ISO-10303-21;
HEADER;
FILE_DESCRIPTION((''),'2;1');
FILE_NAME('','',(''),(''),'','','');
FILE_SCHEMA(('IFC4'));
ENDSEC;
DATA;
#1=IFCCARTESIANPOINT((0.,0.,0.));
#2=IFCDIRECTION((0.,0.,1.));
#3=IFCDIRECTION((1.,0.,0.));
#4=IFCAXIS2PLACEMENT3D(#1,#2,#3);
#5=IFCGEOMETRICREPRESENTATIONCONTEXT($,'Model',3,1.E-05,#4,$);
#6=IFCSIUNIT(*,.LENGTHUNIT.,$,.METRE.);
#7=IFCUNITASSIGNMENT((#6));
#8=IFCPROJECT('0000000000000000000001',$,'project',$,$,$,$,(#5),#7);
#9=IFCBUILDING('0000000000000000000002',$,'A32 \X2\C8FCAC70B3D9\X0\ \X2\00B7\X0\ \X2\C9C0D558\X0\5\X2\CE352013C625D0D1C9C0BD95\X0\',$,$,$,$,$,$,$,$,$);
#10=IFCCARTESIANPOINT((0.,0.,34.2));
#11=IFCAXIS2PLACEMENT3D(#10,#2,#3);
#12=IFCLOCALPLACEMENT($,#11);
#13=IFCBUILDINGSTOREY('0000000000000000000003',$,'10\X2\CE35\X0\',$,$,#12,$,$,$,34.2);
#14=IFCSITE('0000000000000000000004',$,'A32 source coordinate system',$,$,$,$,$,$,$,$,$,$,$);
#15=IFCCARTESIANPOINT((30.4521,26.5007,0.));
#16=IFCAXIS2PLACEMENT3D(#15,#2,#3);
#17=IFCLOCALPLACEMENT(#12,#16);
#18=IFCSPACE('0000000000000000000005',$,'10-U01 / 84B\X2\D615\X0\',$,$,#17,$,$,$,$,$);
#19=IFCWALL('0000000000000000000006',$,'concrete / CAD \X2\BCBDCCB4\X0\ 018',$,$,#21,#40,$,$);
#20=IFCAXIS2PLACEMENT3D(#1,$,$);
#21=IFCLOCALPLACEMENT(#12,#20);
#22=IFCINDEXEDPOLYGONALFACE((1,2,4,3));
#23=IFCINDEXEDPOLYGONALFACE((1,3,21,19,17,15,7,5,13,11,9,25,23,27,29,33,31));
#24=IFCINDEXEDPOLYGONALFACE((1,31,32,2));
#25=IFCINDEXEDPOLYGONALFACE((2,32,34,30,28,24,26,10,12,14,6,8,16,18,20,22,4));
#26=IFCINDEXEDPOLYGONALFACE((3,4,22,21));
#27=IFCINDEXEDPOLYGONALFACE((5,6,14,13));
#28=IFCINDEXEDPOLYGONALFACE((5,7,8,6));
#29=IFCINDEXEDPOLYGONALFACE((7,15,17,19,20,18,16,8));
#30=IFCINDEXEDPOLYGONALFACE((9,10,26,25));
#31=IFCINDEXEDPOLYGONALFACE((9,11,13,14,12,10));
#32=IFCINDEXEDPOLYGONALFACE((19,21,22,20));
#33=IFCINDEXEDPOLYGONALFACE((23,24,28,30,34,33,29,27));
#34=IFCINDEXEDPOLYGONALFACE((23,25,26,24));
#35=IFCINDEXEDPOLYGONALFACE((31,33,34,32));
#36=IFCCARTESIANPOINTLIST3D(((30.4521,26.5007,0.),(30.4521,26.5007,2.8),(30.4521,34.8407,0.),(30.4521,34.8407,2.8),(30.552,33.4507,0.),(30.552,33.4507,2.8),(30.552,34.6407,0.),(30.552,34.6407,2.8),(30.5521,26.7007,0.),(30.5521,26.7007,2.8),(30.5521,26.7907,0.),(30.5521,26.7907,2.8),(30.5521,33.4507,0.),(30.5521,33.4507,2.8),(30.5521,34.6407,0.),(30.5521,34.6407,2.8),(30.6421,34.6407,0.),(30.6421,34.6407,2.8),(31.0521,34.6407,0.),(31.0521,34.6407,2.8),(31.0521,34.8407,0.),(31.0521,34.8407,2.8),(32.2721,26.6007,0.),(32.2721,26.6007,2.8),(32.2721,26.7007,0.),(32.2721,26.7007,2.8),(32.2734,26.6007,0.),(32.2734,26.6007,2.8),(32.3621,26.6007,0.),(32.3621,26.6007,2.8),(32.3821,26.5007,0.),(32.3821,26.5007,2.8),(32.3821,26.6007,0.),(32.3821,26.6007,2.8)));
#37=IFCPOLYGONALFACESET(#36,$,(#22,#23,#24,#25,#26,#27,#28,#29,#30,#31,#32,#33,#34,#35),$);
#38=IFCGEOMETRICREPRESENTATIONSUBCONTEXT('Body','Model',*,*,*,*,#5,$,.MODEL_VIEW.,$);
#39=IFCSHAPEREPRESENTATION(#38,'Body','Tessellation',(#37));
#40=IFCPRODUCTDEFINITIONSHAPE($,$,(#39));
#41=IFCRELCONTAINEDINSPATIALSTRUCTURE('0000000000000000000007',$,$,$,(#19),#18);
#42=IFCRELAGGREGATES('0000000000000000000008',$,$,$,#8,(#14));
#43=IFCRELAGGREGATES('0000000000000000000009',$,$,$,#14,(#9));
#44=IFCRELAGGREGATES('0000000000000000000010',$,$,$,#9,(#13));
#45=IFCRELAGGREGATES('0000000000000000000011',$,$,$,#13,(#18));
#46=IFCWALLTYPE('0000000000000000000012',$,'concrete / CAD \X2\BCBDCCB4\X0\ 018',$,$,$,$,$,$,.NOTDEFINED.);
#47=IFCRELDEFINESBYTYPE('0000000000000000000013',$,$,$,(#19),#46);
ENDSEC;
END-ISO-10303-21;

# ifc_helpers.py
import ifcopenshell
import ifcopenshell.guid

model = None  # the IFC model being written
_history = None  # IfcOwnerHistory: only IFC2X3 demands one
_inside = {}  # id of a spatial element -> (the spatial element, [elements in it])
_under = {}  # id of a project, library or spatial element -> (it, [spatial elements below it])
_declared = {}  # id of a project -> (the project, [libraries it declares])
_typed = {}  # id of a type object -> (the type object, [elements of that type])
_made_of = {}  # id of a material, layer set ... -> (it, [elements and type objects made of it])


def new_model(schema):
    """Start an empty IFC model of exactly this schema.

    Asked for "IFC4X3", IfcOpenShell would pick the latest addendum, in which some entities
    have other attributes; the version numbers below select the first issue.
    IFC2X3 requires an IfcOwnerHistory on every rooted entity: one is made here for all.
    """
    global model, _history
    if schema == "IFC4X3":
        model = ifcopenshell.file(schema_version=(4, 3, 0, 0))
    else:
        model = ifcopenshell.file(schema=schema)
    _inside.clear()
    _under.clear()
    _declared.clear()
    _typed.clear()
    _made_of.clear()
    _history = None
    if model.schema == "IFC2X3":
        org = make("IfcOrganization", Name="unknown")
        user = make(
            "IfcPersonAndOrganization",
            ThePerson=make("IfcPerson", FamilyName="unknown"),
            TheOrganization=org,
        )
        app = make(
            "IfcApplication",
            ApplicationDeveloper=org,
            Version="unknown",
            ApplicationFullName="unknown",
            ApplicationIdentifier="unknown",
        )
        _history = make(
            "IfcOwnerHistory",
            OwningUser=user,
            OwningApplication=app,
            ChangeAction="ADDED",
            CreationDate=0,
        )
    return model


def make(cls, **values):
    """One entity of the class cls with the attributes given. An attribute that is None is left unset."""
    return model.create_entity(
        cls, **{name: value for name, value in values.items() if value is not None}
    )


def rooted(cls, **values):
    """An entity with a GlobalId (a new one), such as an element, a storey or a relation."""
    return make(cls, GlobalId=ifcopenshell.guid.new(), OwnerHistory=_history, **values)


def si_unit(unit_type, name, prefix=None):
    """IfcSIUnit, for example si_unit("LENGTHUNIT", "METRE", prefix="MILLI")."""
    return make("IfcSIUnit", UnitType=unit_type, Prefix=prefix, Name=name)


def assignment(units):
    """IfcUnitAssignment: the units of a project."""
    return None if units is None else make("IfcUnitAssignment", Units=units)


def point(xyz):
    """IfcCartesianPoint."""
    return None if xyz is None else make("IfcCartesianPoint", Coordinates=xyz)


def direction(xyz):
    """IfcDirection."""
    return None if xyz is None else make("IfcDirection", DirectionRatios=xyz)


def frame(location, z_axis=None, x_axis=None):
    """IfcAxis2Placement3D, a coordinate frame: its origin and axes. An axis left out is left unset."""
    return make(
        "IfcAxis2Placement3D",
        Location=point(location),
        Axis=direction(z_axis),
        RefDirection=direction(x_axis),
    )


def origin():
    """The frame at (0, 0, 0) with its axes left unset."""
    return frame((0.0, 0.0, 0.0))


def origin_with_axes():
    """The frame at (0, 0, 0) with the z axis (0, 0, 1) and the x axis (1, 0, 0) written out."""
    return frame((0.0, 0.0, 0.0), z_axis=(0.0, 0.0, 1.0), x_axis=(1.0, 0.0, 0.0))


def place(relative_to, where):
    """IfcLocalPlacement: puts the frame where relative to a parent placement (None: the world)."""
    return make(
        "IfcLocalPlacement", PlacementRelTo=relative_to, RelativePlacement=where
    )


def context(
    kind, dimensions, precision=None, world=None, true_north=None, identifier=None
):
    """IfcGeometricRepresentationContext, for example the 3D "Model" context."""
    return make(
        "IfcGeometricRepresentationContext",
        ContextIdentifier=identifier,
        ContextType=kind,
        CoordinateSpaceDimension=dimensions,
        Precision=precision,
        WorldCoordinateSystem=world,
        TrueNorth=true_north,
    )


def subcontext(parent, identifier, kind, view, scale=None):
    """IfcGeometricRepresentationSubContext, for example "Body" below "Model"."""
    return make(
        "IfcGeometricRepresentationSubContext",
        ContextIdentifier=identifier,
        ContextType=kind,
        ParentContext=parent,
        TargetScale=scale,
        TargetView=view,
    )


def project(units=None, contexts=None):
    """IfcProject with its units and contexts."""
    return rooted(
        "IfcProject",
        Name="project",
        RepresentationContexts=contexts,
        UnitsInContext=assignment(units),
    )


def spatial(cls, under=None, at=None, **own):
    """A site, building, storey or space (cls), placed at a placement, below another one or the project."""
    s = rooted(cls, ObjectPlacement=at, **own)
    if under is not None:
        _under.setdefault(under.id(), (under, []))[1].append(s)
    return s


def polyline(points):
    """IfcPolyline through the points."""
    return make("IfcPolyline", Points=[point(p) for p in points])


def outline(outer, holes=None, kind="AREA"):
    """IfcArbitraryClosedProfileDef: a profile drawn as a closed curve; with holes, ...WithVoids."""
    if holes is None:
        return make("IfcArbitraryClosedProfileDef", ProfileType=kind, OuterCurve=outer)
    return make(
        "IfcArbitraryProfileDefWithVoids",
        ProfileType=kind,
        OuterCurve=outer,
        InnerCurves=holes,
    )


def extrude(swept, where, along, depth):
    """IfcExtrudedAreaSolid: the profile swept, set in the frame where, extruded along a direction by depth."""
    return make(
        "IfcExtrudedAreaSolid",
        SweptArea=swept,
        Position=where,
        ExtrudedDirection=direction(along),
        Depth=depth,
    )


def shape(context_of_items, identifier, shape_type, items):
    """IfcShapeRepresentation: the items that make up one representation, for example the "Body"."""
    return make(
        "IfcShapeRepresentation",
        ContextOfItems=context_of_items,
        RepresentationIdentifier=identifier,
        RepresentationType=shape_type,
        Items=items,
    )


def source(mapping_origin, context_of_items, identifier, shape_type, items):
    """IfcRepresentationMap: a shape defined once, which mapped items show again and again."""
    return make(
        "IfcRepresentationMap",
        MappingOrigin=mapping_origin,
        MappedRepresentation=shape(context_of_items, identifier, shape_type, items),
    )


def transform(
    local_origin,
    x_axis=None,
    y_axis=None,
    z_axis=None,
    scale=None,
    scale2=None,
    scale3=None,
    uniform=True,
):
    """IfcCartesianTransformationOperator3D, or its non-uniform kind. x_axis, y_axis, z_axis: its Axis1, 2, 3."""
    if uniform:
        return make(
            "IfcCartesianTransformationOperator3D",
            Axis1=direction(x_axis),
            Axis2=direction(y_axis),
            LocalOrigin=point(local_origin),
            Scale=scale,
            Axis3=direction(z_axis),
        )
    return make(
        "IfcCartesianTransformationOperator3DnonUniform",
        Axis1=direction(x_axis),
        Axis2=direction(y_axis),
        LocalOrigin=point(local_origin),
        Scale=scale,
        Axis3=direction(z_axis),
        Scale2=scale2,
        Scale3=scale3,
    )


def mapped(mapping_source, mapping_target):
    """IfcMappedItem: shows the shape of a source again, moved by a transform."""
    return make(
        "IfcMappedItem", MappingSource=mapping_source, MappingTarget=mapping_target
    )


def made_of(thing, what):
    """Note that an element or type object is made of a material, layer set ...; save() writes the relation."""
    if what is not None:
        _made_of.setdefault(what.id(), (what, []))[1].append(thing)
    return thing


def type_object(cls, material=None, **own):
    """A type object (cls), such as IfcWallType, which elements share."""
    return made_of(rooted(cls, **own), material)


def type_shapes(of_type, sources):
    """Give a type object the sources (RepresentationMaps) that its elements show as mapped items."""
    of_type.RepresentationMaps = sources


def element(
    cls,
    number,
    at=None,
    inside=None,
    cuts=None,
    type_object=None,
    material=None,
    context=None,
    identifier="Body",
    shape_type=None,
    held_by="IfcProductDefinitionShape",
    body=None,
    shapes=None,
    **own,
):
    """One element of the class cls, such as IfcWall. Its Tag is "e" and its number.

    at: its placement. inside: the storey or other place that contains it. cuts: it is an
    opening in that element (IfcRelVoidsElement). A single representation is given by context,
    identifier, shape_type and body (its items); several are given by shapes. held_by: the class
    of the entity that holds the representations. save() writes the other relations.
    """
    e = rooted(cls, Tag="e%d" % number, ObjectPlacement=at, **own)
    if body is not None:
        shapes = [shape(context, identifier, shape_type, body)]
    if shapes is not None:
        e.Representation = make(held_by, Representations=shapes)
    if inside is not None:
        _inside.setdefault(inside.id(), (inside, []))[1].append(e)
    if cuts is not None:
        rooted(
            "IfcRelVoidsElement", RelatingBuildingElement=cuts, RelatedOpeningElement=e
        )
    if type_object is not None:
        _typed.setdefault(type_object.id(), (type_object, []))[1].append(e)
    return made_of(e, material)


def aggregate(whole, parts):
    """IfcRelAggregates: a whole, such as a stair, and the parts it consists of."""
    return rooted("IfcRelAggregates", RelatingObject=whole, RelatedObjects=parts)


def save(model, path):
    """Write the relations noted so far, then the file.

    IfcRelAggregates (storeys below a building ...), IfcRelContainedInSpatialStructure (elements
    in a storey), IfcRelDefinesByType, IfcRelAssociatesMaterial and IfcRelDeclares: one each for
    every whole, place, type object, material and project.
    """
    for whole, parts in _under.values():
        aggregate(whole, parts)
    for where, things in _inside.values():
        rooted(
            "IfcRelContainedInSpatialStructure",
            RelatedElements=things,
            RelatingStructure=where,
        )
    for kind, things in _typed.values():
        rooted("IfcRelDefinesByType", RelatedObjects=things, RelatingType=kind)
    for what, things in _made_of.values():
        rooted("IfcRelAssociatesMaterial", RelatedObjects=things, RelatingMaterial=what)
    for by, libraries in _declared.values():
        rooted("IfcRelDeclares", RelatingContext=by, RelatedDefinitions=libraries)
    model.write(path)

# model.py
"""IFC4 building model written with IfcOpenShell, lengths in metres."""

from ifc_helpers import new_model, si_unit, frame, origin, origin_with_axes, place, context, subcontext, project, spatial, polyline, outline, extrude, source, transform, mapped, type_object, type_shapes, element, save


model = new_model("IFC4")

# Units and contexts
model_context = context("Model", 3, precision=1e-05, world=origin_with_axes())
body_context = subcontext(model_context, "Body", "Model", "MODEL_VIEW")
ifc_project = project(units=[si_unit("LENGTHUNIT", "METRE")], contexts=[model_context])

# Site, building, storey, space
site = spatial("IfcSite", under=ifc_project, Name="A32 source coordinate system")
building = spatial("IfcBuilding", under=site, Name="A32 주거동 · 지하5층–옥탑지붕")
storey_placement = place(None, frame((0.0, 0.0, 34.2), z_axis=(0.0, 0.0, 1.0), x_axis=(1.0, 0.0, 0.0)))
storey = spatial("IfcBuildingStorey", under=building, at=storey_placement, Name="10층", Elevation=34.2)
space_1_placement = place(storey_placement, frame((30.4521, 26.5007, 0.0), z_axis=(0.0, 0.0, 1.0), x_axis=(1.0, 0.0, 0.0)))
space_1 = spatial("IfcSpace", under=storey, at=space_1_placement, Name="10-U01 / 84B형")

# Wall
wall_type_1 = type_object("IfcWallType", Name="concrete / CAD 벽체 018", PredefinedType="NOTDEFINED")
shared_shape_1 = source(origin(), body_context, "Body", "SweptSolid", [
    extrude(outline(polyline([(0.6, 8.34), (0.6, 8.14), (0.19, 8.14), (0.1, 8.14), (0.0999, 8.14), (0.0999, 6.95), (0.1, 6.95), (0.1, 0.29), (0.1, 0.2), (1.82, 0.2), (1.82, 0.1), (1.8213, 0.1), (1.91, 0.1), (1.93, 0.1), (1.93, 0.0), (0.0, 0.0), (0.0, 8.34), (-0.35, 8.34), (-0.35, 8.34), (0.6, 8.34)])), origin(), (0.0, 0.0, 1.0), 2.8),
])
type_shapes(wall_type_1, [shared_shape_1])
wall_1_placement = place(space_1_placement, origin_with_axes())
element("IfcWall", 1, at=wall_1_placement, inside=space_1, type_object=wall_type_1, Name="concrete / CAD 벽체 018", context=body_context, shape_type="MappedRepresentation", body=[
    mapped(shared_shape_1, transform((0.0, 0.0, 0.0), scale=1.0)),
])

save(model, "model.ifc")
